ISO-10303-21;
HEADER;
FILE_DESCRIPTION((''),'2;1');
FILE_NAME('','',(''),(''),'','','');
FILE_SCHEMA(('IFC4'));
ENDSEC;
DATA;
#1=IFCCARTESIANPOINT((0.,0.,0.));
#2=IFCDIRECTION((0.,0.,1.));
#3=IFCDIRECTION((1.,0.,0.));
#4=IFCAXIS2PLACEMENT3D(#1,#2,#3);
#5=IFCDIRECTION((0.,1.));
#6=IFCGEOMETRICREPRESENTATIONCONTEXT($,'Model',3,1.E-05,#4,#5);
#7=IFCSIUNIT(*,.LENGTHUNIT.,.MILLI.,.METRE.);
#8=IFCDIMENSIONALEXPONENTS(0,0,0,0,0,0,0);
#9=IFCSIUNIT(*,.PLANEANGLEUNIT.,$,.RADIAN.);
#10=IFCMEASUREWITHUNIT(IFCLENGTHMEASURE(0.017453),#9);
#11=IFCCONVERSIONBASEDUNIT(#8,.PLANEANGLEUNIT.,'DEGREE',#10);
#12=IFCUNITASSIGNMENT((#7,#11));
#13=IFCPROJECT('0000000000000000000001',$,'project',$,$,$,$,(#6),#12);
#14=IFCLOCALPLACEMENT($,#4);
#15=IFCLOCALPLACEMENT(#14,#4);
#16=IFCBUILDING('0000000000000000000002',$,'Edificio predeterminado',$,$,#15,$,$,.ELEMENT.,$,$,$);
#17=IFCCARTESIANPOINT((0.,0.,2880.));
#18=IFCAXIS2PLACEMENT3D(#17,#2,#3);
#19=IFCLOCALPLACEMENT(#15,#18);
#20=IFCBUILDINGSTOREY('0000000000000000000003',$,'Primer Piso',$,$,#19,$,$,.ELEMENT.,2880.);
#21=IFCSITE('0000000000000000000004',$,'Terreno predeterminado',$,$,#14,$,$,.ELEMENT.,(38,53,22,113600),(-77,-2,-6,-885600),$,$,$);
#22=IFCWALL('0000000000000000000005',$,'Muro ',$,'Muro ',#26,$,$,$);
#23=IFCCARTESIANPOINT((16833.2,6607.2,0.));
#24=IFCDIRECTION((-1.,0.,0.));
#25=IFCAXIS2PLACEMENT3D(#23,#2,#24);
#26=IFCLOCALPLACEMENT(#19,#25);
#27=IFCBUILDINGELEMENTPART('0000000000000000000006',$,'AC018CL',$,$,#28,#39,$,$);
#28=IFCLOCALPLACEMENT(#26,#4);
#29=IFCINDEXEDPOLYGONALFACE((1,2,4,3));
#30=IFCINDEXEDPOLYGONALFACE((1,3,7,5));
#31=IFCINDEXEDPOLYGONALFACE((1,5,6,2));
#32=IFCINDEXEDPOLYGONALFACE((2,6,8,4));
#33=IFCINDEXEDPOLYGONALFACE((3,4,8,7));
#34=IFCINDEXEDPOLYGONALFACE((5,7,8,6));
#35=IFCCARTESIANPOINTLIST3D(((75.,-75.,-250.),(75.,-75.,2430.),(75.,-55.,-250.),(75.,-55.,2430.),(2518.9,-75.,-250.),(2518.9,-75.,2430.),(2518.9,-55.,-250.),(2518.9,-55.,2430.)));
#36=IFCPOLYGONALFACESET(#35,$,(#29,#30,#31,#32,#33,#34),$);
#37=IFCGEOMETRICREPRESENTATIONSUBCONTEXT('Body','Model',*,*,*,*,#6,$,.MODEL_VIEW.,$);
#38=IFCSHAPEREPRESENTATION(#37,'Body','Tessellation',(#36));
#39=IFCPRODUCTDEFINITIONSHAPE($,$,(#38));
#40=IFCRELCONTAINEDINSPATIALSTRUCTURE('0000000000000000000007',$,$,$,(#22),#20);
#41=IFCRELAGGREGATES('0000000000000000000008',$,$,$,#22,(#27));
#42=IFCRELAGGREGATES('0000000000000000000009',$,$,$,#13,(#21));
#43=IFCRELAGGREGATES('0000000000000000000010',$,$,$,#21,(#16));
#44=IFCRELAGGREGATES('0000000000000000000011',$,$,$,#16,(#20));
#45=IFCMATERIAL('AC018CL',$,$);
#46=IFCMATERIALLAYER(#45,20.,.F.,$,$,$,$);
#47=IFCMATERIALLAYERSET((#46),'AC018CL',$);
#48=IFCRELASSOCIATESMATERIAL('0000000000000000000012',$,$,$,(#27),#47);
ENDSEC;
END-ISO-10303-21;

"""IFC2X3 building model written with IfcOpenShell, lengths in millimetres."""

from ifc_helpers import new_model, entity, si_unit, converted_unit, direction, frame, origin_with_axes, place, context, subcontext, project, spatial, polyline, outline, extrude, material, layer, layer_set, layer_usage, element, aggregate, save


model = new_model("IFC2X3")

# Units and contexts
model_context = context("Model", 3, precision=1e-05, world=origin_with_axes(), true_north=direction((0.0, 1.0)))
body_context = subcontext(model_context, "Body", "Model", "MODEL_VIEW")
ifc_project = project(units=[si_unit("LENGTHUNIT", "METRE", prefix="MILLI"), converted_unit("PLANEANGLEUNIT", "DEGREE", entity("IfcLengthMeasure", 0.017453), si_unit("PLANEANGLEUNIT", "RADIAN"), dimensions=[0, 0, 0, 0, 0, 0, 0])], contexts=[model_context])

# Site, building, storey
site_placement = place(None, origin_with_axes())
site = spatial("IfcSite", under=ifc_project, at=site_placement, Name="Terreno predeterminado", CompositionType="ELEMENT", RefLatitude=(38, 53, 22, 113600), RefLongitude=(-77, -2, -6, -885600))
building_placement = place(site_placement, origin_with_axes())
building = spatial("IfcBuilding", under=site, at=building_placement, Name="Edificio predeterminado", CompositionType="ELEMENT")
storey_placement = place(building_placement, frame((0.0, 0.0, 2880.0), z_axis=(0.0, 0.0, 1.0), x_axis=(1.0, 0.0, 0.0)))
storey = spatial("IfcBuildingStorey", under=building, at=storey_placement, Name="Primer Piso", CompositionType="ELEMENT", Elevation=2880.0)

# Wall, building element part
wall_1_placement = place(storey_placement, frame((16833.2, 6607.2, 0.0), z_axis=(0.0, 0.0, 1.0), x_axis=(-1.0, 0.0, 0.0)))
wall_1 = element("IfcWall", 1, at=wall_1_placement, inside=storey, Name="Muro ", ObjectType="Muro ")
ifc_material_1 = material(Name="AC018CL")
ifc_layer_1 = layer(ifc_material_1, 20.0, ventilated=False)
ifc_layer_set_1 = layer_set([ifc_layer_1], Name="AC018CL")
ifc_layer_usage_1 = layer_usage(ifc_layer_set_1, "AXIS2", "NEGATIVE", 55.0)
building_element_part_1_placement = place(wall_1_placement, origin_with_axes())
building_element_part_1 = element("IfcBuildingElementPart", 2, at=building_element_part_1_placement, material=ifc_layer_usage_1, Name="AC018CL", context=body_context, shape_type="SweptSolid", body=[
    extrude(outline(polyline([(2518.9, -55.0), (2518.9, -75.0), (75.0, -75.0), (75.0, -55.0), (2518.9, -55.0)])), frame((0.0, 0.0, -250.0), z_axis=(0.0, 0.0, 1.0), x_axis=(1.0, 0.0, 0.0)), (0.0, 0.0, 1.0), 2680.0),
])
aggregate(wall_1, [building_element_part_1])

save(model, "model.ifc")
